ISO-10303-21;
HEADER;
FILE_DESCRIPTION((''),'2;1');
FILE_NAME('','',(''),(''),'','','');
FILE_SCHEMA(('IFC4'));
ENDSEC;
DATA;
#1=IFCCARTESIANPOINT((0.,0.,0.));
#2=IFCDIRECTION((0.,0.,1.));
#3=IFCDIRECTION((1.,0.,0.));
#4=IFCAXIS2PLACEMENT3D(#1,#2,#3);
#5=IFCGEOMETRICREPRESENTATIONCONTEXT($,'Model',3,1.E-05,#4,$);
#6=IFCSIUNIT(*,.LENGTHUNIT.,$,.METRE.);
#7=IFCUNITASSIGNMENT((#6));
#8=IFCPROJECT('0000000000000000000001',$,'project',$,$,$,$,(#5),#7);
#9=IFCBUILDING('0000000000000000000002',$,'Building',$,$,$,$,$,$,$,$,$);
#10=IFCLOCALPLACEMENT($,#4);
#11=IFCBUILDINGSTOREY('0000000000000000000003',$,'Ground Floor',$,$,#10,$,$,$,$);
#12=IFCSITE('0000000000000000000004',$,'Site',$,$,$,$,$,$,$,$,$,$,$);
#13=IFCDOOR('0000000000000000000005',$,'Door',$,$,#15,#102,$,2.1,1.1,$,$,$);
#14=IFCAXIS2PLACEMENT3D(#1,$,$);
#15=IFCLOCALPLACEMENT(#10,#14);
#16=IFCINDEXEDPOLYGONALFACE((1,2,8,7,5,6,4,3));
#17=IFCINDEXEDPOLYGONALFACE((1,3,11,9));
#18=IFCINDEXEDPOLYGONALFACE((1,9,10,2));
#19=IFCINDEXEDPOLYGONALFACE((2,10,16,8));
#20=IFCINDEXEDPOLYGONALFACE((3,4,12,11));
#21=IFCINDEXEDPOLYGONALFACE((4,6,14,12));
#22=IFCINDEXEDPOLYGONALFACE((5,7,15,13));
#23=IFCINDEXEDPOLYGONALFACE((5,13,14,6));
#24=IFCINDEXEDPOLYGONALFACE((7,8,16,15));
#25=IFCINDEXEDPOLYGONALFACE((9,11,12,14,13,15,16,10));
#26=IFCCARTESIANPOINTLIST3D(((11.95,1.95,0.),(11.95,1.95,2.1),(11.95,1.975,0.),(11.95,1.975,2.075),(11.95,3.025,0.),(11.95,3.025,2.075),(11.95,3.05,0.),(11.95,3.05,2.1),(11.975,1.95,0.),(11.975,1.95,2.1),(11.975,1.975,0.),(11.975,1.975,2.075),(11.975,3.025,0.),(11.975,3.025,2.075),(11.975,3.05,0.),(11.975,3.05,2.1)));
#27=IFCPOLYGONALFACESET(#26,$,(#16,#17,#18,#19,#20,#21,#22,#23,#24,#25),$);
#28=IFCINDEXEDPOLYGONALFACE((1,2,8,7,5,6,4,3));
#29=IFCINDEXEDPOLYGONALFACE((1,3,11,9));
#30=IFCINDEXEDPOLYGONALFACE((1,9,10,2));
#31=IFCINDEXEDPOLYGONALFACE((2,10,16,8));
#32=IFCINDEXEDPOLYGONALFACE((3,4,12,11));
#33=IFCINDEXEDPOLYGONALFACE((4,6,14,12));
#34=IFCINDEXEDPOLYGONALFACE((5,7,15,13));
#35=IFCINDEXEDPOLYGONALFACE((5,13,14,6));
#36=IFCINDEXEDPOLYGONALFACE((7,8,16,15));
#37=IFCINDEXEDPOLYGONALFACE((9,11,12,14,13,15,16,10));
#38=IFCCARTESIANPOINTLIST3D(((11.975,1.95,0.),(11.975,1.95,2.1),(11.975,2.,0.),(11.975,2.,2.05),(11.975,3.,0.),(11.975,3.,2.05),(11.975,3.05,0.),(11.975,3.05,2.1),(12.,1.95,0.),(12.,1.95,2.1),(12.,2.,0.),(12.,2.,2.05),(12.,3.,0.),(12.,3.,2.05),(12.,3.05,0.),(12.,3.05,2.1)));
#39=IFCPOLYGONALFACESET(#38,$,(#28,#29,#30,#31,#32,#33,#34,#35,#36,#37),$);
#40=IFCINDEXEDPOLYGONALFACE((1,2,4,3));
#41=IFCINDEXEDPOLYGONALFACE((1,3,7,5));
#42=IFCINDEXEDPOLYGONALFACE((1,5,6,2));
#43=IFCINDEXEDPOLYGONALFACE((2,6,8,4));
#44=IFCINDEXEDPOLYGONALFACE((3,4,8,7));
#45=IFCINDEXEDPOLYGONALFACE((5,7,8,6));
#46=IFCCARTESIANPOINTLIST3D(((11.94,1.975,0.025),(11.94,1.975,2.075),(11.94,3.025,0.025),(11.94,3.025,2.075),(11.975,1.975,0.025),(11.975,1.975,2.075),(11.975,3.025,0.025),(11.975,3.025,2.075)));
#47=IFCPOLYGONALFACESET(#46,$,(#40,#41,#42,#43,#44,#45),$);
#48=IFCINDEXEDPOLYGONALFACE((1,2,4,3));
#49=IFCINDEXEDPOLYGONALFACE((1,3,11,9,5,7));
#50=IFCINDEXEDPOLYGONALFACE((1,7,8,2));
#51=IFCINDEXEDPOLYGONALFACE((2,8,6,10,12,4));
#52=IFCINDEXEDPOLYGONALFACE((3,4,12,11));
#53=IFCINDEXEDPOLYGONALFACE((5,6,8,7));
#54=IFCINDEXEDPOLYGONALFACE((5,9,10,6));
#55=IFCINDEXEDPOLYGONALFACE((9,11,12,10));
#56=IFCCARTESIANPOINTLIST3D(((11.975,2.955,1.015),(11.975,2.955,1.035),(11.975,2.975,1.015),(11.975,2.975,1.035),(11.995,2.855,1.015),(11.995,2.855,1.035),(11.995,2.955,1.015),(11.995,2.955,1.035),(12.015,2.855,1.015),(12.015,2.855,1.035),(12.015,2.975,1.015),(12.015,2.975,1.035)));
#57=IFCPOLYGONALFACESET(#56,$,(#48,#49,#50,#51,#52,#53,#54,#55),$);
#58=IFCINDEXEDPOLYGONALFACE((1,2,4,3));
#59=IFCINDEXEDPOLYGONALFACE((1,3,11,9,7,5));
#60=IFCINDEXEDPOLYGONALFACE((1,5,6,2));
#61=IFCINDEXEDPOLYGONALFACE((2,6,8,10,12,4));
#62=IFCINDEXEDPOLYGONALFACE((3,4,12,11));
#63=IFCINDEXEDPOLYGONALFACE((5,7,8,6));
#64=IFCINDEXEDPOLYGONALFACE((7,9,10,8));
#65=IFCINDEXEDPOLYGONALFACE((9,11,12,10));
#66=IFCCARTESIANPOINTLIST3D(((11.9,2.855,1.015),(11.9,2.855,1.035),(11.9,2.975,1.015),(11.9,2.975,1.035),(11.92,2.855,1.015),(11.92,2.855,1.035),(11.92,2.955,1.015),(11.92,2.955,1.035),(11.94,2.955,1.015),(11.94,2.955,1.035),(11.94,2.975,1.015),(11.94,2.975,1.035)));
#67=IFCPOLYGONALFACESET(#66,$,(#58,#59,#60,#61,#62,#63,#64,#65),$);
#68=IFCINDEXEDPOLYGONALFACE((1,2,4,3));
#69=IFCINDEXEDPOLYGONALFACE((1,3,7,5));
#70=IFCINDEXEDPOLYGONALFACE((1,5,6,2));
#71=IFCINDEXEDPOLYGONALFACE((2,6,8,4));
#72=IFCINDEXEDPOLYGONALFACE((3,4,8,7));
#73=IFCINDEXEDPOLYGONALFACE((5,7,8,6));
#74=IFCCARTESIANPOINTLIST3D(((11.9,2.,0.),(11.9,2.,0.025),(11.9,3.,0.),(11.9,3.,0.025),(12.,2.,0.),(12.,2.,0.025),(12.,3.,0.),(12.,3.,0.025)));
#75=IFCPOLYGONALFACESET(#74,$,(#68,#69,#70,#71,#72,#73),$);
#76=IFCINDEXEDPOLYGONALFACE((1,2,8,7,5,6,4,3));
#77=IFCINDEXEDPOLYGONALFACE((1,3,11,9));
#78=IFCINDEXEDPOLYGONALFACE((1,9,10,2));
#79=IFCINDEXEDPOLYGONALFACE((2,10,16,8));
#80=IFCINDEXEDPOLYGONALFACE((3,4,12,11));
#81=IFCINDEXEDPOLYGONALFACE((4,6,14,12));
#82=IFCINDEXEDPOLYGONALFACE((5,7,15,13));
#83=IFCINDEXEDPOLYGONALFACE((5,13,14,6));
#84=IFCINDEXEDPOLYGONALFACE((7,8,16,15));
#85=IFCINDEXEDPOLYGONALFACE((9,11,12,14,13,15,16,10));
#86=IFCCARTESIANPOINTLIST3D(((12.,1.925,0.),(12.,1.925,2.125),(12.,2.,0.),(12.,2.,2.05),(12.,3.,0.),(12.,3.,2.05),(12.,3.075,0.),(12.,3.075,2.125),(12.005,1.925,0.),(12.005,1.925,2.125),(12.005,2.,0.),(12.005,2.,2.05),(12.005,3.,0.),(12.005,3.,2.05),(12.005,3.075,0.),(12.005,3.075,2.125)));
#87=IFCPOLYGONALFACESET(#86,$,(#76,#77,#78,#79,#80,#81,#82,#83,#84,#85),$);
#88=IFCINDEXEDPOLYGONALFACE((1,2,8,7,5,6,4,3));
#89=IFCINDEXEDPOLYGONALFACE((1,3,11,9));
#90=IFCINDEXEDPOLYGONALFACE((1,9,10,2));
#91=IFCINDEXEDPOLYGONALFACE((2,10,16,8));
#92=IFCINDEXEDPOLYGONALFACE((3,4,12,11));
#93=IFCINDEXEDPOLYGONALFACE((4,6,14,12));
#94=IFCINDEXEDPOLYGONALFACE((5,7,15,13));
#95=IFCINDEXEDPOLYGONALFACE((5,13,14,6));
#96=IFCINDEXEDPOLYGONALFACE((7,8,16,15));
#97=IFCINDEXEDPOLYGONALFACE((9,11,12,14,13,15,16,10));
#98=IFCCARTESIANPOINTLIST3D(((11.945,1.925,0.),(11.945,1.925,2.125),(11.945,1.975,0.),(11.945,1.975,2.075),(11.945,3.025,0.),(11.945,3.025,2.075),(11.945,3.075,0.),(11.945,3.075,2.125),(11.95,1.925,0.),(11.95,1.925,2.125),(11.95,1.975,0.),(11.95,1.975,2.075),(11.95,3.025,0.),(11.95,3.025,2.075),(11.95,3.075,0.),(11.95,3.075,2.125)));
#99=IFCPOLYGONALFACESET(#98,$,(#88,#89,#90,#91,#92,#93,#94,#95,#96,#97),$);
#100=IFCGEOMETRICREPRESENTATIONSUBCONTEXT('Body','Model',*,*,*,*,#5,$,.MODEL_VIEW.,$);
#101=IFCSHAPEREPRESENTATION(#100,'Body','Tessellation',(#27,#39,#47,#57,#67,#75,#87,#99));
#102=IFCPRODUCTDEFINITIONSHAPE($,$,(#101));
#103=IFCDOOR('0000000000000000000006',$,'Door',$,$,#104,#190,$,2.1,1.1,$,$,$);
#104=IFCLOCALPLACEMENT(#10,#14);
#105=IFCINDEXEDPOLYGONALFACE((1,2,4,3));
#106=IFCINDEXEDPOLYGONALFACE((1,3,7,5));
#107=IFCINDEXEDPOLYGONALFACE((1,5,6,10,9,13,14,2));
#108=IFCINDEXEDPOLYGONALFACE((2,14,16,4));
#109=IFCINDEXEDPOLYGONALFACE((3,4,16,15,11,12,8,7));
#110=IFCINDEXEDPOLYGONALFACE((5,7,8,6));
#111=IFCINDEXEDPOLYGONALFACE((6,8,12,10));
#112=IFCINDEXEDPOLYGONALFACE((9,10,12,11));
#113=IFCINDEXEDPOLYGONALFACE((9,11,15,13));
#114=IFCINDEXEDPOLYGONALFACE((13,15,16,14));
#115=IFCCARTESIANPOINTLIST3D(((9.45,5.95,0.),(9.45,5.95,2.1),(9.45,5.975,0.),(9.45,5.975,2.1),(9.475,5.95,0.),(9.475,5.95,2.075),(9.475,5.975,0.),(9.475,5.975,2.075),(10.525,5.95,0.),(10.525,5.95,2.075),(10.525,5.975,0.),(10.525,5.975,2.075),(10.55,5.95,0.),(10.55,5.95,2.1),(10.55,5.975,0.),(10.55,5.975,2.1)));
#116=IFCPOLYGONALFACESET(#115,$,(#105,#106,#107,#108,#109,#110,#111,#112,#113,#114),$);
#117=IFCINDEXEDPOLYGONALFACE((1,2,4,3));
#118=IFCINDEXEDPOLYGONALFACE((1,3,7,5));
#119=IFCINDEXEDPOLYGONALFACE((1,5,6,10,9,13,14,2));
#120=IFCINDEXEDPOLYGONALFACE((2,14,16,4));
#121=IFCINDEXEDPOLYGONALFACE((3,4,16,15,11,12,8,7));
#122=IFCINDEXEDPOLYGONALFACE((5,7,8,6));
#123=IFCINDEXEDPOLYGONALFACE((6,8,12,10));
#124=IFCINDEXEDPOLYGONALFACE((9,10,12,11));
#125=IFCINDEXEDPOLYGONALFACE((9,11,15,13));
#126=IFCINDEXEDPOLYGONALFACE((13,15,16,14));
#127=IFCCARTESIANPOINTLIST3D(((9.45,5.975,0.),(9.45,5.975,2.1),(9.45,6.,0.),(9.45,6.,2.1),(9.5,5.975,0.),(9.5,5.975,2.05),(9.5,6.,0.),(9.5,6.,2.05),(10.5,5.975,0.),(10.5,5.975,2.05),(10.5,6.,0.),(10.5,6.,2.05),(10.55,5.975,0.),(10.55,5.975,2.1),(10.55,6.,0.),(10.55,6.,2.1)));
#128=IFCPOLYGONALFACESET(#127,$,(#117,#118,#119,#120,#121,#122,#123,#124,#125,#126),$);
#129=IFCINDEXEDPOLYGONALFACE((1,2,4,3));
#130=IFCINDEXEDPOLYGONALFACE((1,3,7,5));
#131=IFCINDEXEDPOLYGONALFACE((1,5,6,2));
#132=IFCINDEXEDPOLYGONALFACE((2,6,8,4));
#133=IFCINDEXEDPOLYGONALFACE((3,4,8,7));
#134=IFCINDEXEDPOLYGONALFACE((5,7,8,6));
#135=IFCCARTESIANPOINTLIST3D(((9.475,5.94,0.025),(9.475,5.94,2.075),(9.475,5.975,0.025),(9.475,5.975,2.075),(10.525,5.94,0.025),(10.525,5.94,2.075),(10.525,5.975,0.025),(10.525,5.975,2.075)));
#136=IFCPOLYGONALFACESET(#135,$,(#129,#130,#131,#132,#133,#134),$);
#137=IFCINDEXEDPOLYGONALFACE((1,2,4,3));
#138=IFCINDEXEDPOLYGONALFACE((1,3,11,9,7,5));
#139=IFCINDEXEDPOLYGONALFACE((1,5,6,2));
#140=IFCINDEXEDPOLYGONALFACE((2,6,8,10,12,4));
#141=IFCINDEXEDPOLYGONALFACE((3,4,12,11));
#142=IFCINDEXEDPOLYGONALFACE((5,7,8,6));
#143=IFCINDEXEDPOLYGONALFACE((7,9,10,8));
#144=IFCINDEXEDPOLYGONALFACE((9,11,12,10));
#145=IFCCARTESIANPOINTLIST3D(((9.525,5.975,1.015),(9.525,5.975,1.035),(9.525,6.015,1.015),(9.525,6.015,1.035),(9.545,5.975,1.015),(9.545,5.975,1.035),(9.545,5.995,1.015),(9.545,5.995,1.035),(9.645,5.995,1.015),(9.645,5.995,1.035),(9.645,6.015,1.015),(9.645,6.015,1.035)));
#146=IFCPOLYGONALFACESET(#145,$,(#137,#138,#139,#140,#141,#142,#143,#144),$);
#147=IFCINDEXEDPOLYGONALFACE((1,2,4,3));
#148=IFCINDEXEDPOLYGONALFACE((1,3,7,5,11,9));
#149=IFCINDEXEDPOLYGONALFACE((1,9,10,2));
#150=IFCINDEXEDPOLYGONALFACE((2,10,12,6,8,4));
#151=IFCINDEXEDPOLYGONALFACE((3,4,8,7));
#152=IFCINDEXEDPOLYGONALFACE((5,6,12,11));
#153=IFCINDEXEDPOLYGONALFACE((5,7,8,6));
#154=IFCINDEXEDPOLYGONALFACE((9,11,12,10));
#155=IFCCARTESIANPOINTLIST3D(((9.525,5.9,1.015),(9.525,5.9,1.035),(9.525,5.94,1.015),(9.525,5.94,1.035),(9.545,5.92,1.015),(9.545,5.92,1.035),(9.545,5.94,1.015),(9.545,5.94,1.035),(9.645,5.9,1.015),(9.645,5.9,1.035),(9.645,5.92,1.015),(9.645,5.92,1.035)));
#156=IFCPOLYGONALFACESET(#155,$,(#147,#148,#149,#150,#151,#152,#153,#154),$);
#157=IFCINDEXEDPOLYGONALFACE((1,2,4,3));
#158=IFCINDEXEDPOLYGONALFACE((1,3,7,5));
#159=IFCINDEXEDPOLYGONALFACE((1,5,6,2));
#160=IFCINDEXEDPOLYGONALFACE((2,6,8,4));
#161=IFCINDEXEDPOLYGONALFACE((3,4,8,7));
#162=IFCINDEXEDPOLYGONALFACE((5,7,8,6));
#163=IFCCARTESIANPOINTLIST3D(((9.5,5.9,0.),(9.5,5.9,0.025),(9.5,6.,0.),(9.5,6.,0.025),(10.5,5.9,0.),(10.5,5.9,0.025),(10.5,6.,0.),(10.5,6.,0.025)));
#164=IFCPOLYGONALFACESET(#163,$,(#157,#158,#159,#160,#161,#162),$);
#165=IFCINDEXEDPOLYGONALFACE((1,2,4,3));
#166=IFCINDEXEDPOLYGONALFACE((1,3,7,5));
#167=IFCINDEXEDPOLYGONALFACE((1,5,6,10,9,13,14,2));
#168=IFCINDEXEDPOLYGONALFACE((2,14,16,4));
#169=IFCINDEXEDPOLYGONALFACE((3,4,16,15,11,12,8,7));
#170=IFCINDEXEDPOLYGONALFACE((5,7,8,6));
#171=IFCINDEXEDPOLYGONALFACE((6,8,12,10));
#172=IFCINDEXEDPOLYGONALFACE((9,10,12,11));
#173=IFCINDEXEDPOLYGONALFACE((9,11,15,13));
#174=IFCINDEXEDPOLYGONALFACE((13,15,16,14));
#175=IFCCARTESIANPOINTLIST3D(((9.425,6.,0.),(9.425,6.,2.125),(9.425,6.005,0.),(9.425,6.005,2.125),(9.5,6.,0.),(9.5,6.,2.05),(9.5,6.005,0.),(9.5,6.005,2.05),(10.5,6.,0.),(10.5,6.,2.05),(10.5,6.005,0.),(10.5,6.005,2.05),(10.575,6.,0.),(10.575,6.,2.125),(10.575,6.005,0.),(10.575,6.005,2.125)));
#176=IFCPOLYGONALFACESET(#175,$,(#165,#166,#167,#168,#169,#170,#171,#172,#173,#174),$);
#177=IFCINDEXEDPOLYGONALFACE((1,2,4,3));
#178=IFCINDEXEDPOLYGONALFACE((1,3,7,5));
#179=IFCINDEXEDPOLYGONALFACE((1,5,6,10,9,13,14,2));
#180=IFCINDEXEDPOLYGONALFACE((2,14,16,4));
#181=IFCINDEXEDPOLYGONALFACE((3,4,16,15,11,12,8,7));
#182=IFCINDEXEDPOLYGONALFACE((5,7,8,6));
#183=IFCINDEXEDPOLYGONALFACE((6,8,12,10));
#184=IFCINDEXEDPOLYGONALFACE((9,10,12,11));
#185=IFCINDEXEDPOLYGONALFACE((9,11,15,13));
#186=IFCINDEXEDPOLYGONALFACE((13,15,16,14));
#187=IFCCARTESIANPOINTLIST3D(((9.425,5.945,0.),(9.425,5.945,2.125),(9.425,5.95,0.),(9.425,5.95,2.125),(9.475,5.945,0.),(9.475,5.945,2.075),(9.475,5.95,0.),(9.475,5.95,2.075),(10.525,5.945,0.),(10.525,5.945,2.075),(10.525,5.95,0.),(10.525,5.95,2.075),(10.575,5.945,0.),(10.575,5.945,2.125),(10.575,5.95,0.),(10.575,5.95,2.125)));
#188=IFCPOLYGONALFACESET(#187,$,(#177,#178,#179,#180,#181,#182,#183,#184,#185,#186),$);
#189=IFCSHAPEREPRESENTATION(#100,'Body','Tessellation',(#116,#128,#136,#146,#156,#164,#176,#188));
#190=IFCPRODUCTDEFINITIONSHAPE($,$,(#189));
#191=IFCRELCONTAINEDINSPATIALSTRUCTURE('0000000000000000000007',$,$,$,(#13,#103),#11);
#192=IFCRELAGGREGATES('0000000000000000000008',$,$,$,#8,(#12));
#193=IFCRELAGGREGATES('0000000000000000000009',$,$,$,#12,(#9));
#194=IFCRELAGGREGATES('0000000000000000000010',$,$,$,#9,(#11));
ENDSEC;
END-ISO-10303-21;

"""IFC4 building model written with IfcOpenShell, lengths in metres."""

from ifc_helpers import new_model, si_unit, frame, origin_with_axes, place, context, subcontext, project, spatial, line, indexed_curve, outline, extrude, element, save


model = new_model("IFC4")

# Units and contexts
model_context = context("Model", 3, precision=1e-05, world=origin_with_axes())
body_context = subcontext(model_context, "Body", "Model", "MODEL_VIEW")
ifc_project = project(units=[si_unit("LENGTHUNIT", "METRE")], contexts=[model_context])

# Site, building, storey
site = spatial("IfcSite", under=ifc_project, Name="Site")
building = spatial("IfcBuilding", under=site, Name="Building")
storey_placement = place(None, origin_with_axes())
storey = spatial("IfcBuildingStorey", under=building, at=storey_placement, Name="Ground Floor")

# Doors
door_1_placement = place(storey_placement, frame((12.0, 1.95, 0.0), z_axis=(0.0, 0.0, 1.0), x_axis=(0.0, 1.0, 0.0)))
element("IfcDoor", 1, at=door_1_placement, inside=storey, Name="Door", OverallHeight=2.1, OverallWidth=1.1, context=body_context, shape_type="SweptSolid", body=[
    extrude(outline(indexed_curve([(0.0, 0.0), (0.0, 2.1), (1.1, 2.1), (1.1, 0.0), (1.075, 0.0), (1.075, 2.075), (0.025, 2.075), (0.025, 0.0)], segments=[line(1, 2, 3, 4, 5, 6, 7, 8, 1)])), frame((0.0, 0.025, 0.0), z_axis=(0.0, -1.0, 0.0), x_axis=(1.0, 0.0, 0.0)), (0.0, 0.0, -1.0), 0.025),
    extrude(outline(indexed_curve([(0.0, 0.0), (0.0, 2.1), (1.1, 2.1), (1.1, 0.0), (1.05, 0.0), (1.05, 2.05), (0.05, 2.05), (0.05, 0.0)], segments=[line(1, 2, 3, 4, 5, 6, 7, 8, 1)])), frame((0.0, 0.0, 0.0), z_axis=(0.0, -1.0, 0.0), x_axis=(1.0, 0.0, 0.0)), (0.0, 0.0, -1.0), 0.025),
    extrude(outline(indexed_curve([(0.0, 0.0), (1.05, 0.0), (1.05, 0.035), (0.0, 0.035)], segments=[line(1, 2, 3, 4, 1)])), frame((0.025, 0.025, 0.025), z_axis=(0.0, 0.0, 1.0), x_axis=(1.0, 0.0, 0.0)), (0.0, 0.0, 1.0), 2.05),
    extrude(outline(indexed_curve([(0.0, 0.0), (0.0, -0.04), (-0.12, -0.04), (-0.12, -0.02), (-0.02, -0.02), (-0.02, 0.0)], segments=[line(1, 2, 3, 4, 5, 6, 1)])), frame((1.025, 0.025, 1.015), z_axis=(0.0, 0.0, 1.0), x_axis=(1.0, 0.0, 0.0)), (0.0, 0.0, 1.0), 0.02),
    extrude(outline(indexed_curve([(0.0, 0.0), (0.0, 0.04), (-0.12, 0.04), (-0.12, 0.02), (-0.02, 0.02), (-0.02, 0.0)], segments=[line(1, 2, 3, 4, 5, 6, 1)])), frame((1.025, 0.06, 1.015), z_axis=(0.0, 0.0, 1.0), x_axis=(1.0, 0.0, 0.0)), (0.0, 0.0, 1.0), 0.02),
    extrude(outline(indexed_curve([(0.0, 0.0), (1.0, 0.0), (1.0, 0.1), (0.0, 0.1)], segments=[line(1, 2, 3, 4, 1)])), frame((0.05, 0.0, 0.0), z_axis=(0.0, 0.0, 1.0), x_axis=(1.0, 0.0, 0.0)), (0.0, 0.0, 1.0), 0.025),
    extrude(outline(indexed_curve([(0.0, 0.0), (0.0, 2.125), (1.15, 2.125), (1.15, 0.0), (1.075, 0.0), (1.075, 2.05), (0.075, 2.05), (0.075, 0.0)], segments=[line(1, 2, 3, 4, 5, 6, 7, 8, 1)])), frame((-0.025, -0.005, 0.0), z_axis=(0.0, -1.0, 0.0), x_axis=(1.0, 0.0, 0.0)), (0.0, 0.0, -1.0), 0.005),
    extrude(outline(indexed_curve([(0.0, 0.0), (0.0, 2.125), (1.15, 2.125), (1.15, 0.0), (1.1, 0.0), (1.1, 2.075), (0.05, 2.075), (0.05, 0.0)], segments=[line(1, 2, 3, 4, 5, 6, 7, 8, 1)])), frame((-0.025, 0.05, 0.0), z_axis=(0.0, -1.0, 0.0), x_axis=(1.0, 0.0, 0.0)), (0.0, 0.0, -1.0), 0.005),
])
door_2_placement = place(storey_placement, frame((10.55, 6.0, 0.0), z_axis=(0.0, 0.0, 1.0), x_axis=(-1.0, 0.0, 0.0)))
element("IfcDoor", 2, at=door_2_placement, inside=storey, Name="Door", OverallHeight=2.1, OverallWidth=1.1, context=body_context, shape_type="SweptSolid", body=[
    extrude(outline(indexed_curve([(0.0, 0.0), (0.0, 2.1), (1.1, 2.1), (1.1, 0.0), (1.075, 0.0), (1.075, 2.075), (0.025, 2.075), (0.025, 0.0)], segments=[line(1, 2, 3, 4, 5, 6, 7, 8, 1)])), frame((0.0, 0.025, 0.0), z_axis=(0.0, -1.0, 0.0), x_axis=(1.0, 0.0, 0.0)), (0.0, 0.0, -1.0), 0.025),
    extrude(outline(indexed_curve([(0.0, 0.0), (0.0, 2.1), (1.1, 2.1), (1.1, 0.0), (1.05, 0.0), (1.05, 2.05), (0.05, 2.05), (0.05, 0.0)], segments=[line(1, 2, 3, 4, 5, 6, 7, 8, 1)])), frame((0.0, 0.0, 0.0), z_axis=(0.0, -1.0, 0.0), x_axis=(1.0, 0.0, 0.0)), (0.0, 0.0, -1.0), 0.025),
    extrude(outline(indexed_curve([(0.0, 0.0), (1.05, 0.0), (1.05, 0.035), (0.0, 0.035)], segments=[line(1, 2, 3, 4, 1)])), frame((0.025, 0.025, 0.025), z_axis=(0.0, 0.0, 1.0), x_axis=(1.0, 0.0, 0.0)), (0.0, 0.0, 1.0), 2.05),
    extrude(outline(indexed_curve([(0.0, 0.0), (0.0, -0.04), (-0.12, -0.04), (-0.12, -0.02), (-0.02, -0.02), (-0.02, 0.0)], segments=[line(1, 2, 3, 4, 5, 6, 1)])), frame((1.025, 0.025, 1.015), z_axis=(0.0, 0.0, 1.0), x_axis=(1.0, 0.0, 0.0)), (0.0, 0.0, 1.0), 0.02),
    extrude(outline(indexed_curve([(0.0, 0.0), (0.0, 0.04), (-0.12, 0.04), (-0.12, 0.02), (-0.02, 0.02), (-0.02, 0.0)], segments=[line(1, 2, 3, 4, 5, 6, 1)])), frame((1.025, 0.06, 1.015), z_axis=(0.0, 0.0, 1.0), x_axis=(1.0, 0.0, 0.0)), (0.0, 0.0, 1.0), 0.02),
    extrude(outline(indexed_curve([(0.0, 0.0), (1.0, 0.0), (1.0, 0.1), (0.0, 0.1)], segments=[line(1, 2, 3, 4, 1)])), frame((0.05, 0.0, 0.0), z_axis=(0.0, 0.0, 1.0), x_axis=(1.0, 0.0, 0.0)), (0.0, 0.0, 1.0), 0.025),
    extrude(outline(indexed_curve([(0.0, 0.0), (0.0, 2.125), (1.15, 2.125), (1.15, 0.0), (1.075, 0.0), (1.075, 2.05), (0.075, 2.05), (0.075, 0.0)], segments=[line(1, 2, 3, 4, 5, 6, 7, 8, 1)])), frame((-0.025, -0.005, 0.0), z_axis=(0.0, -1.0, 0.0), x_axis=(1.0, 0.0, 0.0)), (0.0, 0.0, -1.0), 0.005),
    extrude(outline(indexed_curve([(0.0, 0.0), (0.0, 2.125), (1.15, 2.125), (1.15, 0.0), (1.1, 0.0), (1.1, 2.075), (0.05, 2.075), (0.05, 0.0)], segments=[line(1, 2, 3, 4, 5, 6, 7, 8, 1)])), frame((-0.025, 0.05, 0.0), z_axis=(0.0, -1.0, 0.0), x_axis=(1.0, 0.0, 0.0)), (0.0, 0.0, -1.0), 0.005),
])

save(model, "model.ifc")
